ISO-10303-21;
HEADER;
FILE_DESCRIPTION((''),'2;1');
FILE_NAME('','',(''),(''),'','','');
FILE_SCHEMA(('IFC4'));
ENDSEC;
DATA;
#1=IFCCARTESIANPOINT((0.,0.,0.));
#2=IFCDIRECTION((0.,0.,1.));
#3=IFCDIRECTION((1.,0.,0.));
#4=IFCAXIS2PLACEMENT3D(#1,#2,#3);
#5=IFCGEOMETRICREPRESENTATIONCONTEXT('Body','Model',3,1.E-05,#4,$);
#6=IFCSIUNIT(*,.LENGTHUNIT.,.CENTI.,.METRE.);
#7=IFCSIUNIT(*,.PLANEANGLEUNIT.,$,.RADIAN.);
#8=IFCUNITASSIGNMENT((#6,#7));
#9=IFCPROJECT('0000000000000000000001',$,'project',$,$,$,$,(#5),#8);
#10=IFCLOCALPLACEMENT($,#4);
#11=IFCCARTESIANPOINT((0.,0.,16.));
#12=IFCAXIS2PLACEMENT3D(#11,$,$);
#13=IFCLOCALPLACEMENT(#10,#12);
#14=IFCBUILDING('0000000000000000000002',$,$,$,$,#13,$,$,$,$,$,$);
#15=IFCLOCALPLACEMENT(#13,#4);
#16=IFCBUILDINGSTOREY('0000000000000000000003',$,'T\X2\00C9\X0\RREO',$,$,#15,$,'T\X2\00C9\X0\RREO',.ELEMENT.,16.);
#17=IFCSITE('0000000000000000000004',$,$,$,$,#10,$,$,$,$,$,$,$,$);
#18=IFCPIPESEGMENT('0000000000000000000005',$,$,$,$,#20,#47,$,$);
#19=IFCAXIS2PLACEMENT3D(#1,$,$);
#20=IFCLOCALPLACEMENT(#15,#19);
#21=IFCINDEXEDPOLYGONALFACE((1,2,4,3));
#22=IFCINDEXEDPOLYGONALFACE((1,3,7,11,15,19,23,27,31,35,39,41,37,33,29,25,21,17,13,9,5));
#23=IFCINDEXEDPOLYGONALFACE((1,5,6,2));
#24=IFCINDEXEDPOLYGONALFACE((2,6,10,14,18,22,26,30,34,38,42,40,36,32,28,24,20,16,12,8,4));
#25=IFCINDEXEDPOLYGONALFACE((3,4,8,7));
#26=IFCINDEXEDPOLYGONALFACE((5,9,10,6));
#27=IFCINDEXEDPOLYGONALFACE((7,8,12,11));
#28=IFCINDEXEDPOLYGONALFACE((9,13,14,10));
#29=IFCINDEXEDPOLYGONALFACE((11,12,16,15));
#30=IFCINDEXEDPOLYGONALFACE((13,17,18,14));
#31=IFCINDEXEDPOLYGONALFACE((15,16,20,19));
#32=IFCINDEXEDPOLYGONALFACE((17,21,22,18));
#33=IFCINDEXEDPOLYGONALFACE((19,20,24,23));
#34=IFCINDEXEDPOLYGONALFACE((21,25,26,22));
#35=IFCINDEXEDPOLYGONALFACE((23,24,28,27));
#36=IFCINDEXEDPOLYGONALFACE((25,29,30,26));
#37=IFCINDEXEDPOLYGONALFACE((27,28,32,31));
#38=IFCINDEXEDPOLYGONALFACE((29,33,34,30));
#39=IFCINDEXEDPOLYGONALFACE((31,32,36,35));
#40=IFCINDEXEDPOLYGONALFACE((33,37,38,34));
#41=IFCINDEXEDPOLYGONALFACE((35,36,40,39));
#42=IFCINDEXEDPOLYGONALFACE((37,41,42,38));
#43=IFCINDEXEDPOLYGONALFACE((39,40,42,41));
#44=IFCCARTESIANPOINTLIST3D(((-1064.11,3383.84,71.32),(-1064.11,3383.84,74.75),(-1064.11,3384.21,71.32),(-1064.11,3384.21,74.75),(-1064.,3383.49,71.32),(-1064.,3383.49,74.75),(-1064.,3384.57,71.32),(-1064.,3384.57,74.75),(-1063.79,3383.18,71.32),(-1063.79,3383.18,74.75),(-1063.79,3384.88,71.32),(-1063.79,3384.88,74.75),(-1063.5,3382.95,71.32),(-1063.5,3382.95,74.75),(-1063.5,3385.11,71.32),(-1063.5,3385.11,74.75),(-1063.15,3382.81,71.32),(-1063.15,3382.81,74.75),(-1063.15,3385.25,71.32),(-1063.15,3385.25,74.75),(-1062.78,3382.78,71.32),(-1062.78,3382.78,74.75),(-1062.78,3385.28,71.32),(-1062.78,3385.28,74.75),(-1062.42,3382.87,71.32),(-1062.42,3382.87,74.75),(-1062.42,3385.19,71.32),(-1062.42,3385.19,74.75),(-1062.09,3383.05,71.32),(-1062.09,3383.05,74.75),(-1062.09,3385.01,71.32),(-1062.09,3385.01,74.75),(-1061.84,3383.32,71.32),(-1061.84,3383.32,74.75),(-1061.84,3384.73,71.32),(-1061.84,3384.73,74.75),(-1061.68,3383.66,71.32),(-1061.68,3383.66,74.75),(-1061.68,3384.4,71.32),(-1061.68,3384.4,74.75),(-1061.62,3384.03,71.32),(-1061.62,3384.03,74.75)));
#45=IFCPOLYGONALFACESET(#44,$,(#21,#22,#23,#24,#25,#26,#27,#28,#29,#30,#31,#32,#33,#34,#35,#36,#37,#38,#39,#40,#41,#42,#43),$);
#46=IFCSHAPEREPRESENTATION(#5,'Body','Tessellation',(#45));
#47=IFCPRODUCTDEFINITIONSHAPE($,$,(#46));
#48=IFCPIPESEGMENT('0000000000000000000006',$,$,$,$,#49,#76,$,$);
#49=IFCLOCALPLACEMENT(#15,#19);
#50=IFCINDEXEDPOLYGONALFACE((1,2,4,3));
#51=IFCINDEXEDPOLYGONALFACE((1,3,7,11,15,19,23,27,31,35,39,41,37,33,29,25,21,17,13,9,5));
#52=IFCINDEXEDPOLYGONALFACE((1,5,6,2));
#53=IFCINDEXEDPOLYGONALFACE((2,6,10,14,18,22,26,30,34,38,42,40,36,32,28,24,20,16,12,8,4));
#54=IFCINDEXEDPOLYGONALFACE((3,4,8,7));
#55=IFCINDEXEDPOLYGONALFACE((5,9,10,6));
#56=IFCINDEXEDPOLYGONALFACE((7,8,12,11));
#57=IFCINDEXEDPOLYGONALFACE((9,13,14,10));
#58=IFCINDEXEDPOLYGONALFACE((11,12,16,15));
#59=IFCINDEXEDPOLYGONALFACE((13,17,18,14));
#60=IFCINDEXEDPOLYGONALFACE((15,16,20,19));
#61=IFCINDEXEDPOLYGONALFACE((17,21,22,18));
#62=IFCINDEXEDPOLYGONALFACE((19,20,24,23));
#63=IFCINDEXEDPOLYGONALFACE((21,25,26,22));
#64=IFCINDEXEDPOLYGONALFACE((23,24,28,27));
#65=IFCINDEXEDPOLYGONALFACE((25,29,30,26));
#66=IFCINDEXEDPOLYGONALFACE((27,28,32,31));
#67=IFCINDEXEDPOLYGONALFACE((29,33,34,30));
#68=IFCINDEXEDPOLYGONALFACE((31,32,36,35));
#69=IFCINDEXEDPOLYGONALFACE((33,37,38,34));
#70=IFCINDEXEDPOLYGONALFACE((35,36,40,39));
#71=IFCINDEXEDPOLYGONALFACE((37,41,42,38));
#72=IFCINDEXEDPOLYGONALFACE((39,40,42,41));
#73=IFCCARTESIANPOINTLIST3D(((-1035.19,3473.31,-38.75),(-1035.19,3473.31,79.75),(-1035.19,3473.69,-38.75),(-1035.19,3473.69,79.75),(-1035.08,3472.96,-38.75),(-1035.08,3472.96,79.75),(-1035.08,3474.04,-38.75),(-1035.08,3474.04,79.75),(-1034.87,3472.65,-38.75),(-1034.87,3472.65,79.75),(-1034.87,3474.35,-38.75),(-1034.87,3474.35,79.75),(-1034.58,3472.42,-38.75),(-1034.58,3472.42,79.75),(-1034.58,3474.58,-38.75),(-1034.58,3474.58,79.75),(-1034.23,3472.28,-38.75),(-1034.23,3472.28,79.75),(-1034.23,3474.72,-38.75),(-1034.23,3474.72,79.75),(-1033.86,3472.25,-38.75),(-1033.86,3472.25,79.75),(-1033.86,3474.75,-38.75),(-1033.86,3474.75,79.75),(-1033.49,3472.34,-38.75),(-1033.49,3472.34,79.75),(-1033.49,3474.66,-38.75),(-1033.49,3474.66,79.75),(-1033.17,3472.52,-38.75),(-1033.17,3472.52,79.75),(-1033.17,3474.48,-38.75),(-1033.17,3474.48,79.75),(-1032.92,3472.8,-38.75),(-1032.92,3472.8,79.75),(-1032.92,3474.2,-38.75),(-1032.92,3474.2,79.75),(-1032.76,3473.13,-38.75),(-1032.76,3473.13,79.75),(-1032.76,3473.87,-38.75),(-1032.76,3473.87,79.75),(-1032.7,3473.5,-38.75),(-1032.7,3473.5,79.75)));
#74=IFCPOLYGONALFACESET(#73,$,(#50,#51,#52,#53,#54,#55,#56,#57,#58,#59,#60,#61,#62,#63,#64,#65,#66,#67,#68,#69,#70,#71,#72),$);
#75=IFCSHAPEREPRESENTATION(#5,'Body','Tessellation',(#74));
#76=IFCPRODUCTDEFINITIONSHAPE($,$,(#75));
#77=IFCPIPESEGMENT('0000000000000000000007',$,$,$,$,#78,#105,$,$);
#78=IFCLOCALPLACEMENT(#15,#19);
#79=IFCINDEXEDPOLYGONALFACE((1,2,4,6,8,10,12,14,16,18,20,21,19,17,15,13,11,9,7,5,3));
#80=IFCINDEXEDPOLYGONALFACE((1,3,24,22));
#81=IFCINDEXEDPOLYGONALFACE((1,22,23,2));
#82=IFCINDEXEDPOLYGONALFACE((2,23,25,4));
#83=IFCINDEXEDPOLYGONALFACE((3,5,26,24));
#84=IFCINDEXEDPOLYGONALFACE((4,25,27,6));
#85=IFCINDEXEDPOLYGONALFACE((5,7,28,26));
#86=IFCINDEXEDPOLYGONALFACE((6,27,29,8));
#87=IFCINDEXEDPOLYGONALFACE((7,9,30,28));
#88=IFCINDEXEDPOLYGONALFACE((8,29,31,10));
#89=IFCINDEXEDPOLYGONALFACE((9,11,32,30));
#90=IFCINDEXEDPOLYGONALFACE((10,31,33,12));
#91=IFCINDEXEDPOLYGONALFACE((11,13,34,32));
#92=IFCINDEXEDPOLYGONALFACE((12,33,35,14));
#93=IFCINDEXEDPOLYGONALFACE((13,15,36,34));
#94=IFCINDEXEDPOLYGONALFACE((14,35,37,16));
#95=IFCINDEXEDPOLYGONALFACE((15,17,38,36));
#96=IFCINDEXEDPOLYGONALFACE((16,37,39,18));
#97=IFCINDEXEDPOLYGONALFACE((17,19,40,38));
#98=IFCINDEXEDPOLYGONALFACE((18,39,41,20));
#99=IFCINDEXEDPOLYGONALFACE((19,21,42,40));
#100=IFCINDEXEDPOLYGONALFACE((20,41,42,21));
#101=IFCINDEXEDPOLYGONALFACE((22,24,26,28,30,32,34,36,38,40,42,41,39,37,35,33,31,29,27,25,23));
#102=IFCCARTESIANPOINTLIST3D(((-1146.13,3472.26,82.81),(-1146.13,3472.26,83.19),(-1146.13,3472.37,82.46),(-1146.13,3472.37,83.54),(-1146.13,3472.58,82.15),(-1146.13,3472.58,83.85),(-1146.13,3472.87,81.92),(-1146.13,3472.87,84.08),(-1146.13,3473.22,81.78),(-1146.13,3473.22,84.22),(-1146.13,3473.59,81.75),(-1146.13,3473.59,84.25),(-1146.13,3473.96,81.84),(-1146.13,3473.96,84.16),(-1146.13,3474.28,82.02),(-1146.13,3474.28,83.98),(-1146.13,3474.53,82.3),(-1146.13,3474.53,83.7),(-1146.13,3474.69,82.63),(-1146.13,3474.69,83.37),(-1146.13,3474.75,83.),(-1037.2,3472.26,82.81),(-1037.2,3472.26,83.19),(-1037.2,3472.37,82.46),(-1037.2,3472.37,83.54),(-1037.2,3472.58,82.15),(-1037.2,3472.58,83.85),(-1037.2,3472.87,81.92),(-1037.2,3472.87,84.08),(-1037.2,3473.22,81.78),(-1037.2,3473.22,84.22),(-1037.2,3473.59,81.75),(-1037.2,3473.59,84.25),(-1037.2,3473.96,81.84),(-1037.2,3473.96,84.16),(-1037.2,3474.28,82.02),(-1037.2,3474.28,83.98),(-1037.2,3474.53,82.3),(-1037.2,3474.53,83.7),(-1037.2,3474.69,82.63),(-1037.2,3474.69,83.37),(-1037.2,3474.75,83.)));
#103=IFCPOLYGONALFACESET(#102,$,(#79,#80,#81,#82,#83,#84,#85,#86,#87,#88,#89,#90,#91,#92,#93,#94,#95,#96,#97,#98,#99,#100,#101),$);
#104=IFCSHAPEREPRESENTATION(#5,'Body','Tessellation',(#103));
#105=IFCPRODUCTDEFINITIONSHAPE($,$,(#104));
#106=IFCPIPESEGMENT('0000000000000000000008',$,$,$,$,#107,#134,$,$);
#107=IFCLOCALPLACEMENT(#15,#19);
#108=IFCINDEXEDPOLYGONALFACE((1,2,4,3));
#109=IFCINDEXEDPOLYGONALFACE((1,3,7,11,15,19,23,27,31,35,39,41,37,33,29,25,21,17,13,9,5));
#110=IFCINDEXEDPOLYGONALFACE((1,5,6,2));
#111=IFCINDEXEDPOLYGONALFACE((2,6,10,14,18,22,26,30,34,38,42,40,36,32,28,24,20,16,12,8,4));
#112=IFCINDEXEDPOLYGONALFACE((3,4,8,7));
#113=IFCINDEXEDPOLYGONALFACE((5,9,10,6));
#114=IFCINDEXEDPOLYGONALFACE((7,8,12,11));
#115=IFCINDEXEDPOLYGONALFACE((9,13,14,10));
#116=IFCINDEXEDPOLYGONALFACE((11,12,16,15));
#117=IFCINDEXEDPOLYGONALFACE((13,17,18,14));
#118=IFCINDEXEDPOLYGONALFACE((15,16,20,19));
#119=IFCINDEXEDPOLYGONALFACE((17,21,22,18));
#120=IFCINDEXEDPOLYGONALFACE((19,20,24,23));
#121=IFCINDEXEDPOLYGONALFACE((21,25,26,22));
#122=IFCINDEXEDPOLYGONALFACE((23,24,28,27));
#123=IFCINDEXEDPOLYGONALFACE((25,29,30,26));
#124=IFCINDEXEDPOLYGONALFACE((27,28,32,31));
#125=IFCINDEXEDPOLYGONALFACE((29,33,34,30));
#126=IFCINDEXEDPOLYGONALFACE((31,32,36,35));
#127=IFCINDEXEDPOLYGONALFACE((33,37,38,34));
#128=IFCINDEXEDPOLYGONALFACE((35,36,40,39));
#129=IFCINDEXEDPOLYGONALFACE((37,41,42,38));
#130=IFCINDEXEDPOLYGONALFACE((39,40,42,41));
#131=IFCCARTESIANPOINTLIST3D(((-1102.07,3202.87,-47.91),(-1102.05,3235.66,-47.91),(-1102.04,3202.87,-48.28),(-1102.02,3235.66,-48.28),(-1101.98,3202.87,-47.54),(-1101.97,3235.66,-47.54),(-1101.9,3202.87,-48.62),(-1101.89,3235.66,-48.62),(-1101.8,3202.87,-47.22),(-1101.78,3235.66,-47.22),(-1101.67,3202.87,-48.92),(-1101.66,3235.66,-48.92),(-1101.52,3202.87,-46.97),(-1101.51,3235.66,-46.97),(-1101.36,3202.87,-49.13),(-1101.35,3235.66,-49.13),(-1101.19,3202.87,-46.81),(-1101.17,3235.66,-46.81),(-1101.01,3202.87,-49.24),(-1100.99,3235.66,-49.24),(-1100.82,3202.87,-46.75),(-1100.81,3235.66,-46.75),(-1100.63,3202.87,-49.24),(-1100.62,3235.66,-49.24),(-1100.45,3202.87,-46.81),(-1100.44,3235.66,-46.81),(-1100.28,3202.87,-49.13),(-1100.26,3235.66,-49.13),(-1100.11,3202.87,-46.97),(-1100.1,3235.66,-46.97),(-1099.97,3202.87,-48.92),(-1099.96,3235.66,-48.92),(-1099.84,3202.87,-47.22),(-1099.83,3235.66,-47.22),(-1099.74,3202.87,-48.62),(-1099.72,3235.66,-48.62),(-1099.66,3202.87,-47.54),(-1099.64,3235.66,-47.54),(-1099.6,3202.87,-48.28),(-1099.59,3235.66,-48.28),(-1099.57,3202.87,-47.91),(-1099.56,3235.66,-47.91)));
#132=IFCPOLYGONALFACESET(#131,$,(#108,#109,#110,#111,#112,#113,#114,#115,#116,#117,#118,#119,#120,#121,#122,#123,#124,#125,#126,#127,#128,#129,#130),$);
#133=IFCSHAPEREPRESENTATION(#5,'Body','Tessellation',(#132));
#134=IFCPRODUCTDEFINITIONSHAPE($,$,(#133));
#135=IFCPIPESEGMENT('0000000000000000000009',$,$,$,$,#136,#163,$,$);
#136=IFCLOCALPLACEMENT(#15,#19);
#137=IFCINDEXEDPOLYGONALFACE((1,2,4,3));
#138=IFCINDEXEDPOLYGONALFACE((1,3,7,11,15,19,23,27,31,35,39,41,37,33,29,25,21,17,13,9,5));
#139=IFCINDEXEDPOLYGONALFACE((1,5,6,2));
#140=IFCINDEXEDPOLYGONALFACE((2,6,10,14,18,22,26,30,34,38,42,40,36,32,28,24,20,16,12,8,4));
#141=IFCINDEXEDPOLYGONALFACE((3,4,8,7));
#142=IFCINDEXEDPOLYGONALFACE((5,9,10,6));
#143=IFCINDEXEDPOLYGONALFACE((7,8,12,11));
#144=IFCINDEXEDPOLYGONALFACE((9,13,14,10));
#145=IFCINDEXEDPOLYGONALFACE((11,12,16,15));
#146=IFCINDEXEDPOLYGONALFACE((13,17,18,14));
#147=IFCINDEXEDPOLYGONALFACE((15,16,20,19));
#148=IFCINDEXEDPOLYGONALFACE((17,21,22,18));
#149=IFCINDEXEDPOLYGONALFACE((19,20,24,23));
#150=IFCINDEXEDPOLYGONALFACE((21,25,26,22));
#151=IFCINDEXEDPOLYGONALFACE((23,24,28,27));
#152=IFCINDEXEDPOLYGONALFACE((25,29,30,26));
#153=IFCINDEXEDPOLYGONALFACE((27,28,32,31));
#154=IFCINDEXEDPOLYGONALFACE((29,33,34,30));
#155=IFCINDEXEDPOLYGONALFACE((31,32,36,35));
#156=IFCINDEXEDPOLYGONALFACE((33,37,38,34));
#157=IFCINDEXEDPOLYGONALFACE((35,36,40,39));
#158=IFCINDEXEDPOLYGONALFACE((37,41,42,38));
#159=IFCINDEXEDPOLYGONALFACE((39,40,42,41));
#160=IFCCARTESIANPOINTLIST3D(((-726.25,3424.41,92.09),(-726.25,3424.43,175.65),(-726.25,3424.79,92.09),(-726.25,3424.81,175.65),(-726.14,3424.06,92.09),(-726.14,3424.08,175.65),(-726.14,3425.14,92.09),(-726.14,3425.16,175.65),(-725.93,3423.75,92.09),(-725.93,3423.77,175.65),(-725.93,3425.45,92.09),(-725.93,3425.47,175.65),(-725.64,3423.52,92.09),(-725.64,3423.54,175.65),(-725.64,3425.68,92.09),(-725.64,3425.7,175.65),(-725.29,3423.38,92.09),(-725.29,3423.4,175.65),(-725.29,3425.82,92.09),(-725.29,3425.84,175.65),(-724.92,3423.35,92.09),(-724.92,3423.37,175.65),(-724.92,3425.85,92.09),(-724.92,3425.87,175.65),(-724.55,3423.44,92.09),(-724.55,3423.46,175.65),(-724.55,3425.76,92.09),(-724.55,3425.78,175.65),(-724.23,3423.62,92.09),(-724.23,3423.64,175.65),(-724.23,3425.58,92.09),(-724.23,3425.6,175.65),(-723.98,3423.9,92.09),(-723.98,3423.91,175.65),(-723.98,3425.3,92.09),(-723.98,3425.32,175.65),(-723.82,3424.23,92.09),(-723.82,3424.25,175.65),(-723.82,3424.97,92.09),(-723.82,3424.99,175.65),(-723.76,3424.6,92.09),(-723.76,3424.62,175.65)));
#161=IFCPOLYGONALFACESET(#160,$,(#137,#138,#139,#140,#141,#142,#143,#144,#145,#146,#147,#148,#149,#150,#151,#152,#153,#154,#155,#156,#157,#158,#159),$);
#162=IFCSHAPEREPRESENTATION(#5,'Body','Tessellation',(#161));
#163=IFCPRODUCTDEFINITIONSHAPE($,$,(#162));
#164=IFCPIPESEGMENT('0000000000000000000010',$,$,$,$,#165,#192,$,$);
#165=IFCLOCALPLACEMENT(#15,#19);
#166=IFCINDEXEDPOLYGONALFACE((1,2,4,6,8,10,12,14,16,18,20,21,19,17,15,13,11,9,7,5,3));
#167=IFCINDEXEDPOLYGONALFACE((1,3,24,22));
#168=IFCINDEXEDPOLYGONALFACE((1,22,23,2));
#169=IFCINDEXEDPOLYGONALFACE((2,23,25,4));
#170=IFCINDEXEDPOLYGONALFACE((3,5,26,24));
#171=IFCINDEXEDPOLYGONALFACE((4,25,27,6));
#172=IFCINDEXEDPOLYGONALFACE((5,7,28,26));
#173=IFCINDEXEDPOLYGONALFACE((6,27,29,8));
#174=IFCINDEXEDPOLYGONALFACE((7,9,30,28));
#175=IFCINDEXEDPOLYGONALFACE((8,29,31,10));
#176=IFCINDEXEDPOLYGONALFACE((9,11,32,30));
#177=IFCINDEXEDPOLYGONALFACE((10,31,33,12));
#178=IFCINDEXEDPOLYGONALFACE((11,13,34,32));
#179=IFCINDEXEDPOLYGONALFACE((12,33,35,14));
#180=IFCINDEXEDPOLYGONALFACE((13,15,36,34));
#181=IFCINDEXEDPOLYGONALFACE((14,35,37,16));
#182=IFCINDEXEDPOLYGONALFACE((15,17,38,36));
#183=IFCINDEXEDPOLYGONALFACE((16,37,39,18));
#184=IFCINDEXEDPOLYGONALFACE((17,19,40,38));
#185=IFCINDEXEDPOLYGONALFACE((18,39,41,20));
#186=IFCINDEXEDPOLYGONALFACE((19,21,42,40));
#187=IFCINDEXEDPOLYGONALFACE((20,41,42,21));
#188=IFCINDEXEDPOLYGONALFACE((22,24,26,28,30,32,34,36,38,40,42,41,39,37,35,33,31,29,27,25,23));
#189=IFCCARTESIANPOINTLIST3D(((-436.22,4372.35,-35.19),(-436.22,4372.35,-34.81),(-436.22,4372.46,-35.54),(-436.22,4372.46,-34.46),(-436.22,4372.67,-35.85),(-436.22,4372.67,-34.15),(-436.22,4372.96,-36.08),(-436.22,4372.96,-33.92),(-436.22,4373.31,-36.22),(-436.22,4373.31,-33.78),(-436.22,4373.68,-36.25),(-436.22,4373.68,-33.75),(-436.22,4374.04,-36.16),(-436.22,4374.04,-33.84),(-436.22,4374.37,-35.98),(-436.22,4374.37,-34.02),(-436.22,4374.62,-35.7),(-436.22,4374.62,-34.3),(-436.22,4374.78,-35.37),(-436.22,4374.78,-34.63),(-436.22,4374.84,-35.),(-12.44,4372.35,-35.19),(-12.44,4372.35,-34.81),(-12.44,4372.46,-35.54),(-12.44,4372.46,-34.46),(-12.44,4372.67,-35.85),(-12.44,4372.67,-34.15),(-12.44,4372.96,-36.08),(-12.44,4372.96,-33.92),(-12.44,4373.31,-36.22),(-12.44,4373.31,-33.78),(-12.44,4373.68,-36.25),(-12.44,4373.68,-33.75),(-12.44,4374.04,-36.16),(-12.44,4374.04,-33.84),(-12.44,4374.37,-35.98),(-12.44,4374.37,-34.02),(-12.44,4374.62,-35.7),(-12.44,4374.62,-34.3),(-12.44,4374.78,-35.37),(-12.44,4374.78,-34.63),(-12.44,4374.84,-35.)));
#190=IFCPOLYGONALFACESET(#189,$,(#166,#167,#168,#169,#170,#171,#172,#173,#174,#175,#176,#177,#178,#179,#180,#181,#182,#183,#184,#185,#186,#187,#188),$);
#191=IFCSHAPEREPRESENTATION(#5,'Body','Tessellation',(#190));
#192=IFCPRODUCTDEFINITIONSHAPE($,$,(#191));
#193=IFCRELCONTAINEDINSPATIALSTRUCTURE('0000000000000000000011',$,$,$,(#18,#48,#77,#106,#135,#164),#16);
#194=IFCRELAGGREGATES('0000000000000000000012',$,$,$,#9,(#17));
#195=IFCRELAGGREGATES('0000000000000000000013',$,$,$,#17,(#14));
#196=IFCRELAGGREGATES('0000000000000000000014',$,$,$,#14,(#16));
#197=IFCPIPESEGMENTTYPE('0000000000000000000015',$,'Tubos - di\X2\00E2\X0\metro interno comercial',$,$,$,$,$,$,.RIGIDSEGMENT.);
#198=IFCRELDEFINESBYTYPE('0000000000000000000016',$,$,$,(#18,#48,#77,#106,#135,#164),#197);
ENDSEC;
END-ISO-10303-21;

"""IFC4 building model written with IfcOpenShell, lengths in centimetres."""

from ifc_helpers import new_model, si_unit, frame, origin_with_axes, origin_2d_with_axis, place, context, project, spatial, circle, extrude, type_object, element, save


model = new_model("IFC4")

# Units and contexts
model_context = context("Model", 3, precision=1e-05, world=origin_with_axes(), identifier="Body")
ifc_project = project(units=[si_unit("LENGTHUNIT", "METRE", prefix="CENTI"), si_unit("PLANEANGLEUNIT", "RADIAN")], contexts=[model_context])

# Site, building, storey
site_placement = place(None, origin_with_axes())
site = spatial("IfcSite", under=ifc_project, at=site_placement)
building_placement = place(site_placement, frame((0.0, 0.0, 16.0)))
building = spatial("IfcBuilding", under=site, at=building_placement)
storey_placement = place(building_placement, origin_with_axes())
storey = spatial("IfcBuildingStorey", under=building, at=storey_placement, Name="TÉRREO", LongName="TÉRREO", CompositionType="ELEMENT", Elevation=16.0)

# Pipe segments
pipe_segment_type = type_object("IfcPipeSegmentType", Name="Tubos - diâmetro interno comercial", PredefinedType="RIGIDSEGMENT")
pipe_segment_1_placement = place(storey_placement, frame((-1062.87, 3384.03, 74.75), z_axis=(0.0, 0.0, 1.0), x_axis=(1.0, 0.0, 0.0)))
element("IfcPipeSegment", 1, at=pipe_segment_1_placement, inside=storey, type_object=pipe_segment_type, context=model_context, shape_type="SolidModel", body=[
    extrude(circle(Radius=1.25, at=origin_2d_with_axis()), frame((0.0, 0.0, -3.43), z_axis=(0.0, 0.0, 1.0), x_axis=(1.0, 0.0, 0.0)), (0.0, 0.0, 1.0), 3.43),
])
pipe_segment_2_placement = place(storey_placement, frame((-1033.95, 3473.5, 79.75), z_axis=(0.0, 0.0, 1.0), x_axis=(1.0, 0.0, 0.0)))
element("IfcPipeSegment", 2, at=pipe_segment_2_placement, inside=storey, type_object=pipe_segment_type, context=model_context, shape_type="SolidModel", body=[
    extrude(circle(Radius=1.25, at=origin_2d_with_axis()), frame((0.0, 0.0, 0.0), z_axis=(0.0, 0.0, -1.0), x_axis=(1.0, 0.0, 0.0)), (0.0, 0.0, 1.0), 118.5),
])
pipe_segment_3_placement = place(storey_placement, frame((-1091.67, 3473.5, 84.25), z_axis=(0.0, 0.0, 1.0), x_axis=(1.0, 0.0, 0.0)))
element("IfcPipeSegment", 3, at=pipe_segment_3_placement, inside=storey, type_object=pipe_segment_type, context=model_context, shape_type="SolidModel", body=[
    extrude(circle(Radius=1.25, at=origin_2d_with_axis()), frame((54.47, 0.0, -1.25), z_axis=(-1.0, 0.0, 0.0), x_axis=(0.0, 1.0, 0.0)), (0.0, 0.0, 1.0), 108.93),
])
pipe_segment_4_placement = place(storey_placement, frame((-1100.81, 3219.26, -46.75), z_axis=(0.0, 0.0, 1.0), x_axis=(1.0, 0.0, 0.0)))
element("IfcPipeSegment", 4, at=pipe_segment_4_placement, inside=storey, type_object=pipe_segment_type, context=model_context, shape_type="SolidModel", body=[
    extrude(circle(Radius=1.25, at=origin_2d_with_axis()), frame((-0.01, -16.4, -1.25), z_axis=(0.000396, 1.0, 0.0), x_axis=(0.0, 0.0, 1.0)), (0.0, 0.0, 1.0), 32.79),
])
pipe_segment_5_placement = place(storey_placement, frame((-725.01, 3424.61, 175.65), z_axis=(0.0, 0.0, 1.0), x_axis=(1.0, 0.0, 0.0)))
element("IfcPipeSegment", 5, at=pipe_segment_5_placement, inside=storey, type_object=pipe_segment_type, context=model_context, shape_type="SolidModel", body=[
    extrude(circle(Radius=1.25, at=origin_2d_with_axis()), frame((0.0, 0.01, 0.0), z_axis=(0.0, -0.000227, -1.0), x_axis=(1.0, 0.0, 0.0)), (0.0, 0.0, 1.0), 83.56),
])
pipe_segment_6_placement = place(storey_placement, frame((-224.33, 4373.59, -33.75), z_axis=(0.0, 0.0, 1.0), x_axis=(1.0, 0.0, 0.0)))
element("IfcPipeSegment", 6, at=pipe_segment_6_placement, inside=storey, type_object=pipe_segment_type, context=model_context, shape_type="SolidModel", body=[
    extrude(circle(Radius=1.25, at=origin_2d_with_axis()), frame((211.89, 0.0, -1.25), z_axis=(-1.0, 0.0, 0.0), x_axis=(0.0, 1.0, 0.0)), (0.0, 0.0, 1.0), 423.78),
])

save(model, "model.ifc")
